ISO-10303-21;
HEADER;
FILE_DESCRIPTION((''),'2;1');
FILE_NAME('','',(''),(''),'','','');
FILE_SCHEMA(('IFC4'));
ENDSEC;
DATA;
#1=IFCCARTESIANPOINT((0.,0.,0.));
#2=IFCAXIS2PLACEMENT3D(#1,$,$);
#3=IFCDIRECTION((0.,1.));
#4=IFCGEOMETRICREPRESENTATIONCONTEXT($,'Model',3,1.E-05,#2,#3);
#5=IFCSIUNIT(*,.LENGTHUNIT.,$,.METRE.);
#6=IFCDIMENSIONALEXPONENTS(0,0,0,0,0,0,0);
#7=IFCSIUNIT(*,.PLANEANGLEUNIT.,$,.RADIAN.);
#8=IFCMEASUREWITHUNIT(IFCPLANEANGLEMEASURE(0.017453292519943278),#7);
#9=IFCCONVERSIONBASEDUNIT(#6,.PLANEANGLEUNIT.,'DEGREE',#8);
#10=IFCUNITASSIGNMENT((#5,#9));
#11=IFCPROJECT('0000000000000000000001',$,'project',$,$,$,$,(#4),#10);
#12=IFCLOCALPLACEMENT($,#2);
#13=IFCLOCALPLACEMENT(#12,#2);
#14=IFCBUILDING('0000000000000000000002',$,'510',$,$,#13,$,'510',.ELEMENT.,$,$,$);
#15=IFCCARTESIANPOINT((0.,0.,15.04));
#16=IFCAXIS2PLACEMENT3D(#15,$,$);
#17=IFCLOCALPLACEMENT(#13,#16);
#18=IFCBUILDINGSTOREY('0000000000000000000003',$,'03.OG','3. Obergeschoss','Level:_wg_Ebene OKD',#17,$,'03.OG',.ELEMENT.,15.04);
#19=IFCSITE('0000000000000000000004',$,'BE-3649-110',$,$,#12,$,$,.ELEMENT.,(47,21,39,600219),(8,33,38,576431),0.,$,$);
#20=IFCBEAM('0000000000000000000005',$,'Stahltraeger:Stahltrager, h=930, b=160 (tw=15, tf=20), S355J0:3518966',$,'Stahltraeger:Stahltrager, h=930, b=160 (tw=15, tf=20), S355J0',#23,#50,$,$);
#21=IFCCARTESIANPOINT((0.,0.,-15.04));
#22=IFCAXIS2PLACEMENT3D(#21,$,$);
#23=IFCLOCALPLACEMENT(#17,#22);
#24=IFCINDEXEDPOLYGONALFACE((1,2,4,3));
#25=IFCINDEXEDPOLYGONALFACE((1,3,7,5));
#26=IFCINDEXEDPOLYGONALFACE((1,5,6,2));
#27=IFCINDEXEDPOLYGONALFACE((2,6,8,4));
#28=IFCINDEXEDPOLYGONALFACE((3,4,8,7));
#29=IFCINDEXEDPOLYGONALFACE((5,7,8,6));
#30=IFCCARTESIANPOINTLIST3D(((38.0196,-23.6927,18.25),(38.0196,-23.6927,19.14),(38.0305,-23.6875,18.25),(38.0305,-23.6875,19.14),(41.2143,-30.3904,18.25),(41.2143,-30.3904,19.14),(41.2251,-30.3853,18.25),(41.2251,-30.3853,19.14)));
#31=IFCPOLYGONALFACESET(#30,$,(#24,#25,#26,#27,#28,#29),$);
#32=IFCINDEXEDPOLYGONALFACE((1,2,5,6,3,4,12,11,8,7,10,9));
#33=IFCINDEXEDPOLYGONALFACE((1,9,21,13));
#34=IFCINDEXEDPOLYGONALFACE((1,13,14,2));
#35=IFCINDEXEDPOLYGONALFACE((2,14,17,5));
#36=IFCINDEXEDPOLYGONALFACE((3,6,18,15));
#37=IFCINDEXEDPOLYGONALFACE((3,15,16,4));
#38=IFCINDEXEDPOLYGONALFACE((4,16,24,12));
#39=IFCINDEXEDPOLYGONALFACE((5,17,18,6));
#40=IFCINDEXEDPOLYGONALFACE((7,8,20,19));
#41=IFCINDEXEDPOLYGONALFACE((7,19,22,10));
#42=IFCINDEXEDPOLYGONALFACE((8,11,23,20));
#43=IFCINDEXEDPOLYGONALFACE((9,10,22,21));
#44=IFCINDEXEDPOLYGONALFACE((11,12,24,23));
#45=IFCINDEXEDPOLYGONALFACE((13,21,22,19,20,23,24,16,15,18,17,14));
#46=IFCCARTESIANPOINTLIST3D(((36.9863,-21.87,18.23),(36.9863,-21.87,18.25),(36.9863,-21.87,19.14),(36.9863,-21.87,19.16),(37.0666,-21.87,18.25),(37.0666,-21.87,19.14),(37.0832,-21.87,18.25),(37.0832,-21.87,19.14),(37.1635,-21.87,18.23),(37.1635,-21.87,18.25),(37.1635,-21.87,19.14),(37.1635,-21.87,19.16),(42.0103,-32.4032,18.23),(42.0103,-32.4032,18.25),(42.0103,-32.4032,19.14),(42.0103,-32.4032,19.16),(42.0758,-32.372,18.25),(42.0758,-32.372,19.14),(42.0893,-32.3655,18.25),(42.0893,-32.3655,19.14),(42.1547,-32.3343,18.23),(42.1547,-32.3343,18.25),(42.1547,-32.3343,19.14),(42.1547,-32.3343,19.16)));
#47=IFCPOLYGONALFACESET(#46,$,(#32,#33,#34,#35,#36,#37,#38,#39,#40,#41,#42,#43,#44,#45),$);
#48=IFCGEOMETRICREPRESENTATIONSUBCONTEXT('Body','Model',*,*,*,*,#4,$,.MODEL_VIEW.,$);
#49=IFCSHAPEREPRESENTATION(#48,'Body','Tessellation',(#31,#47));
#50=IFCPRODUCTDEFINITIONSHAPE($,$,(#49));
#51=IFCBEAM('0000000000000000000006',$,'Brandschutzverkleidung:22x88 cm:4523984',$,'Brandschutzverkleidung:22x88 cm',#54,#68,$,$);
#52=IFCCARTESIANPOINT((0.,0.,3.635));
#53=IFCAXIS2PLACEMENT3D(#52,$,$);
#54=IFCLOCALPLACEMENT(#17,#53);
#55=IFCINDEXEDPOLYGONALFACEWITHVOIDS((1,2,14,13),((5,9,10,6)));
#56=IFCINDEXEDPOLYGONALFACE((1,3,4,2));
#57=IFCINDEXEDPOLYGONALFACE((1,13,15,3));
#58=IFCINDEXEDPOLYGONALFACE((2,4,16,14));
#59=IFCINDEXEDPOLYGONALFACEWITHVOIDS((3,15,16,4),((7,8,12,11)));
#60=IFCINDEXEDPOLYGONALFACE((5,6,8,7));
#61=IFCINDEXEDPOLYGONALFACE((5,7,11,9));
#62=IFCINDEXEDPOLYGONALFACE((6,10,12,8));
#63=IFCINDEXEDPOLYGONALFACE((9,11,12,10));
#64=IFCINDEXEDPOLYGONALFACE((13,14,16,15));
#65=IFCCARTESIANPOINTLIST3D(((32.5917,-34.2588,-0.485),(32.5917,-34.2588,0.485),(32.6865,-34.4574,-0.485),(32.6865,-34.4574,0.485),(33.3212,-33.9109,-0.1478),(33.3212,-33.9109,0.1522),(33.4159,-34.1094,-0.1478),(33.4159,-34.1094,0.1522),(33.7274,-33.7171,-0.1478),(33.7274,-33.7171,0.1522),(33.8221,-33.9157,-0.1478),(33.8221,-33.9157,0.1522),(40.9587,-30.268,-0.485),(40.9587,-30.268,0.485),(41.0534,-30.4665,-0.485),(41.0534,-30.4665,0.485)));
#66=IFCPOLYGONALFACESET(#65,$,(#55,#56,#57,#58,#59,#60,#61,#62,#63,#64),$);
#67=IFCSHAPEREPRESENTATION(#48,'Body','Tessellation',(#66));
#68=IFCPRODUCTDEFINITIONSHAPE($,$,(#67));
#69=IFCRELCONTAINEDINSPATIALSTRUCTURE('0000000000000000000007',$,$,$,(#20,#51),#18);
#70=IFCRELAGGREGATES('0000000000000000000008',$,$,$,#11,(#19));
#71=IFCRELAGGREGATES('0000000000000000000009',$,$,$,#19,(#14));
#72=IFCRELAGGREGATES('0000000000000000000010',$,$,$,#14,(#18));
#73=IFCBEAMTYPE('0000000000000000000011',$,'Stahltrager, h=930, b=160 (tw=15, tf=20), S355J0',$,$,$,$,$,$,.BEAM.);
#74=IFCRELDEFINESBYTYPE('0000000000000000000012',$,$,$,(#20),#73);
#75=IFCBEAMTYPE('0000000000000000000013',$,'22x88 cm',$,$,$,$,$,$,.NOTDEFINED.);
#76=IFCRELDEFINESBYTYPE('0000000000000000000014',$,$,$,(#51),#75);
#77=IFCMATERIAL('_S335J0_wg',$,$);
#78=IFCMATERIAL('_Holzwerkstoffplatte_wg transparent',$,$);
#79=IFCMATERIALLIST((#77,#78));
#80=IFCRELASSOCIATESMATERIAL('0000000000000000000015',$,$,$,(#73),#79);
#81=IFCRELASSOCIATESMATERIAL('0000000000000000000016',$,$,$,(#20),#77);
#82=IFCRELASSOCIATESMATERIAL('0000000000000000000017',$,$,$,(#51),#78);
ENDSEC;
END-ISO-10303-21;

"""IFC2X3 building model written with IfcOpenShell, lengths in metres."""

from ifc_helpers import new_model, entity, si_unit, converted_unit, direction, frame, frame_2d, origin, place, context, subcontext, project, spatial, polyline, rectangle, i_section, outline, extrude, clip, halfspace, source, transform, mapped, material, material_list, type_object, type_shapes, element, save


model = new_model("IFC2X3")

# Units and contexts
model_context = context("Model", 3, precision=1e-05, world=origin(), true_north=direction((0.0, 1.0)))
body_context = subcontext(model_context, "Body", "Model", "MODEL_VIEW")
ifc_project = project(units=[si_unit("LENGTHUNIT", "METRE"), converted_unit("PLANEANGLEUNIT", "DEGREE", entity("IfcPlaneAngleMeasure", 0.017453292519943278), si_unit("PLANEANGLEUNIT", "RADIAN"), dimensions=[0, 0, 0, 0, 0, 0, 0])], contexts=[model_context])

# Site, building, storey
site_placement = place(None, origin())
site = spatial("IfcSite", under=ifc_project, at=site_placement, Name="BE-3649-110", CompositionType="ELEMENT", RefLatitude=(47, 21, 39, 600219), RefLongitude=(8, 33, 38, 576431), RefElevation=0.0)
building_placement = place(site_placement, origin())
building = spatial("IfcBuilding", under=site, at=building_placement, Name="510", LongName="510", CompositionType="ELEMENT")
storey_placement = place(building_placement, frame((0.0, 0.0, 15.04)))
storey = spatial("IfcBuildingStorey", under=building, at=storey_placement, Name="03.OG", Description="3. Obergeschoss", ObjectType="Level:_wg_Ebene OKD", LongName="03.OG", CompositionType="ELEMENT", Elevation=15.04)

# Beams
ifc_material_1 = material(Name="_S335J0_wg")
ifc_material_2 = material(Name="_Holzwerkstoffplatte_wg transparent")
ifc_material_list = material_list([ifc_material_1, ifc_material_2])
beam_type_1 = type_object("IfcBeamType", Name="Stahltrager, h=930, b=160 (tw=15, tf=20), S355J0", PredefinedType="BEAM", material=ifc_material_list)
shared_shape_1 = source(origin(), body_context, "Body", "SweptSolid", [
    extrude(rectangle(XDim=0.89, YDim=0.012, at=frame_2d((0.0, 0.0), x_axis=(1.0, 0.0))), frame((38.025, -23.6901, 18.695), z_axis=(0.430511, -0.902585, 0.0), x_axis=(0.0, 0.0, -1.0)), (0.0, 0.0, 1.0), 7.4206),
    clip(extrude(i_section(OverallWidth=0.16, OverallDepth=0.93, WebThickness=0.015, FlangeThickness=0.02, at=frame_2d((0.0, 0.0), x_axis=(0.0, 1.0))), frame((37.0585, -21.8356, 18.695), z_axis=(0.430511, -0.902585, 0.0), x_axis=(0.0, 0.0, -1.0)), (0.0, 0.0, 1.0), 11.67), halfspace(frame((37.2664, -21.87, 6.877), z_axis=(0.0, 1.0, 0.0), x_axis=(0.0, 0.0, 1.0)), False)),
])
type_shapes(beam_type_1, [shared_shape_1])
beam_1_placement = place(storey_placement, frame((0.0, 0.0, -15.04)))
element("IfcBeam", 1, at=beam_1_placement, inside=storey, type_object=beam_type_1, material=ifc_material_1, Name="Stahltraeger:Stahltrager, h=930, b=160 (tw=15, tf=20), S355J0:3518966", ObjectType="Stahltraeger:Stahltrager, h=930, b=160 (tw=15, tf=20), S355J0", context=body_context, shape_type="MappedRepresentation", body=[
    mapped(shared_shape_1, transform((0.0, 0.0, 0.0), scale=1.0)),
])
beam_type_2 = type_object("IfcBeamType", Name="22x88 cm", PredefinedType="NOTDEFINED")
beam_2_placement = place(storey_placement, frame((0.0, 0.0, 3.635)))
element("IfcBeam", 2, at=beam_2_placement, inside=storey, type_object=beam_type_2, material=ifc_material_2, Name="Brandschutzverkleidung:22x88 cm:4523984", ObjectType="Brandschutzverkleidung:22x88 cm", context=body_context, shape_type="SweptSolid", body=[
    extrude(outline(polyline([(-4.635, -0.485), (4.635, -0.485), (4.635, 0.485), (-4.635, 0.485), (-4.635, -0.485)]), holes=[polyline([(3.3768, -0.1478), (3.3768, 0.1522), (3.8268, 0.1522), (3.8268, -0.1478), (3.3768, -0.1478)])]), frame((36.8699, -32.462, 0.0), z_axis=(-0.430511, 0.902585, 0.0), x_axis=(-0.902585, -0.430511, 0.0)), (0.0, 0.0, 1.0), 0.22),
])

save(model, "model.ifc")
